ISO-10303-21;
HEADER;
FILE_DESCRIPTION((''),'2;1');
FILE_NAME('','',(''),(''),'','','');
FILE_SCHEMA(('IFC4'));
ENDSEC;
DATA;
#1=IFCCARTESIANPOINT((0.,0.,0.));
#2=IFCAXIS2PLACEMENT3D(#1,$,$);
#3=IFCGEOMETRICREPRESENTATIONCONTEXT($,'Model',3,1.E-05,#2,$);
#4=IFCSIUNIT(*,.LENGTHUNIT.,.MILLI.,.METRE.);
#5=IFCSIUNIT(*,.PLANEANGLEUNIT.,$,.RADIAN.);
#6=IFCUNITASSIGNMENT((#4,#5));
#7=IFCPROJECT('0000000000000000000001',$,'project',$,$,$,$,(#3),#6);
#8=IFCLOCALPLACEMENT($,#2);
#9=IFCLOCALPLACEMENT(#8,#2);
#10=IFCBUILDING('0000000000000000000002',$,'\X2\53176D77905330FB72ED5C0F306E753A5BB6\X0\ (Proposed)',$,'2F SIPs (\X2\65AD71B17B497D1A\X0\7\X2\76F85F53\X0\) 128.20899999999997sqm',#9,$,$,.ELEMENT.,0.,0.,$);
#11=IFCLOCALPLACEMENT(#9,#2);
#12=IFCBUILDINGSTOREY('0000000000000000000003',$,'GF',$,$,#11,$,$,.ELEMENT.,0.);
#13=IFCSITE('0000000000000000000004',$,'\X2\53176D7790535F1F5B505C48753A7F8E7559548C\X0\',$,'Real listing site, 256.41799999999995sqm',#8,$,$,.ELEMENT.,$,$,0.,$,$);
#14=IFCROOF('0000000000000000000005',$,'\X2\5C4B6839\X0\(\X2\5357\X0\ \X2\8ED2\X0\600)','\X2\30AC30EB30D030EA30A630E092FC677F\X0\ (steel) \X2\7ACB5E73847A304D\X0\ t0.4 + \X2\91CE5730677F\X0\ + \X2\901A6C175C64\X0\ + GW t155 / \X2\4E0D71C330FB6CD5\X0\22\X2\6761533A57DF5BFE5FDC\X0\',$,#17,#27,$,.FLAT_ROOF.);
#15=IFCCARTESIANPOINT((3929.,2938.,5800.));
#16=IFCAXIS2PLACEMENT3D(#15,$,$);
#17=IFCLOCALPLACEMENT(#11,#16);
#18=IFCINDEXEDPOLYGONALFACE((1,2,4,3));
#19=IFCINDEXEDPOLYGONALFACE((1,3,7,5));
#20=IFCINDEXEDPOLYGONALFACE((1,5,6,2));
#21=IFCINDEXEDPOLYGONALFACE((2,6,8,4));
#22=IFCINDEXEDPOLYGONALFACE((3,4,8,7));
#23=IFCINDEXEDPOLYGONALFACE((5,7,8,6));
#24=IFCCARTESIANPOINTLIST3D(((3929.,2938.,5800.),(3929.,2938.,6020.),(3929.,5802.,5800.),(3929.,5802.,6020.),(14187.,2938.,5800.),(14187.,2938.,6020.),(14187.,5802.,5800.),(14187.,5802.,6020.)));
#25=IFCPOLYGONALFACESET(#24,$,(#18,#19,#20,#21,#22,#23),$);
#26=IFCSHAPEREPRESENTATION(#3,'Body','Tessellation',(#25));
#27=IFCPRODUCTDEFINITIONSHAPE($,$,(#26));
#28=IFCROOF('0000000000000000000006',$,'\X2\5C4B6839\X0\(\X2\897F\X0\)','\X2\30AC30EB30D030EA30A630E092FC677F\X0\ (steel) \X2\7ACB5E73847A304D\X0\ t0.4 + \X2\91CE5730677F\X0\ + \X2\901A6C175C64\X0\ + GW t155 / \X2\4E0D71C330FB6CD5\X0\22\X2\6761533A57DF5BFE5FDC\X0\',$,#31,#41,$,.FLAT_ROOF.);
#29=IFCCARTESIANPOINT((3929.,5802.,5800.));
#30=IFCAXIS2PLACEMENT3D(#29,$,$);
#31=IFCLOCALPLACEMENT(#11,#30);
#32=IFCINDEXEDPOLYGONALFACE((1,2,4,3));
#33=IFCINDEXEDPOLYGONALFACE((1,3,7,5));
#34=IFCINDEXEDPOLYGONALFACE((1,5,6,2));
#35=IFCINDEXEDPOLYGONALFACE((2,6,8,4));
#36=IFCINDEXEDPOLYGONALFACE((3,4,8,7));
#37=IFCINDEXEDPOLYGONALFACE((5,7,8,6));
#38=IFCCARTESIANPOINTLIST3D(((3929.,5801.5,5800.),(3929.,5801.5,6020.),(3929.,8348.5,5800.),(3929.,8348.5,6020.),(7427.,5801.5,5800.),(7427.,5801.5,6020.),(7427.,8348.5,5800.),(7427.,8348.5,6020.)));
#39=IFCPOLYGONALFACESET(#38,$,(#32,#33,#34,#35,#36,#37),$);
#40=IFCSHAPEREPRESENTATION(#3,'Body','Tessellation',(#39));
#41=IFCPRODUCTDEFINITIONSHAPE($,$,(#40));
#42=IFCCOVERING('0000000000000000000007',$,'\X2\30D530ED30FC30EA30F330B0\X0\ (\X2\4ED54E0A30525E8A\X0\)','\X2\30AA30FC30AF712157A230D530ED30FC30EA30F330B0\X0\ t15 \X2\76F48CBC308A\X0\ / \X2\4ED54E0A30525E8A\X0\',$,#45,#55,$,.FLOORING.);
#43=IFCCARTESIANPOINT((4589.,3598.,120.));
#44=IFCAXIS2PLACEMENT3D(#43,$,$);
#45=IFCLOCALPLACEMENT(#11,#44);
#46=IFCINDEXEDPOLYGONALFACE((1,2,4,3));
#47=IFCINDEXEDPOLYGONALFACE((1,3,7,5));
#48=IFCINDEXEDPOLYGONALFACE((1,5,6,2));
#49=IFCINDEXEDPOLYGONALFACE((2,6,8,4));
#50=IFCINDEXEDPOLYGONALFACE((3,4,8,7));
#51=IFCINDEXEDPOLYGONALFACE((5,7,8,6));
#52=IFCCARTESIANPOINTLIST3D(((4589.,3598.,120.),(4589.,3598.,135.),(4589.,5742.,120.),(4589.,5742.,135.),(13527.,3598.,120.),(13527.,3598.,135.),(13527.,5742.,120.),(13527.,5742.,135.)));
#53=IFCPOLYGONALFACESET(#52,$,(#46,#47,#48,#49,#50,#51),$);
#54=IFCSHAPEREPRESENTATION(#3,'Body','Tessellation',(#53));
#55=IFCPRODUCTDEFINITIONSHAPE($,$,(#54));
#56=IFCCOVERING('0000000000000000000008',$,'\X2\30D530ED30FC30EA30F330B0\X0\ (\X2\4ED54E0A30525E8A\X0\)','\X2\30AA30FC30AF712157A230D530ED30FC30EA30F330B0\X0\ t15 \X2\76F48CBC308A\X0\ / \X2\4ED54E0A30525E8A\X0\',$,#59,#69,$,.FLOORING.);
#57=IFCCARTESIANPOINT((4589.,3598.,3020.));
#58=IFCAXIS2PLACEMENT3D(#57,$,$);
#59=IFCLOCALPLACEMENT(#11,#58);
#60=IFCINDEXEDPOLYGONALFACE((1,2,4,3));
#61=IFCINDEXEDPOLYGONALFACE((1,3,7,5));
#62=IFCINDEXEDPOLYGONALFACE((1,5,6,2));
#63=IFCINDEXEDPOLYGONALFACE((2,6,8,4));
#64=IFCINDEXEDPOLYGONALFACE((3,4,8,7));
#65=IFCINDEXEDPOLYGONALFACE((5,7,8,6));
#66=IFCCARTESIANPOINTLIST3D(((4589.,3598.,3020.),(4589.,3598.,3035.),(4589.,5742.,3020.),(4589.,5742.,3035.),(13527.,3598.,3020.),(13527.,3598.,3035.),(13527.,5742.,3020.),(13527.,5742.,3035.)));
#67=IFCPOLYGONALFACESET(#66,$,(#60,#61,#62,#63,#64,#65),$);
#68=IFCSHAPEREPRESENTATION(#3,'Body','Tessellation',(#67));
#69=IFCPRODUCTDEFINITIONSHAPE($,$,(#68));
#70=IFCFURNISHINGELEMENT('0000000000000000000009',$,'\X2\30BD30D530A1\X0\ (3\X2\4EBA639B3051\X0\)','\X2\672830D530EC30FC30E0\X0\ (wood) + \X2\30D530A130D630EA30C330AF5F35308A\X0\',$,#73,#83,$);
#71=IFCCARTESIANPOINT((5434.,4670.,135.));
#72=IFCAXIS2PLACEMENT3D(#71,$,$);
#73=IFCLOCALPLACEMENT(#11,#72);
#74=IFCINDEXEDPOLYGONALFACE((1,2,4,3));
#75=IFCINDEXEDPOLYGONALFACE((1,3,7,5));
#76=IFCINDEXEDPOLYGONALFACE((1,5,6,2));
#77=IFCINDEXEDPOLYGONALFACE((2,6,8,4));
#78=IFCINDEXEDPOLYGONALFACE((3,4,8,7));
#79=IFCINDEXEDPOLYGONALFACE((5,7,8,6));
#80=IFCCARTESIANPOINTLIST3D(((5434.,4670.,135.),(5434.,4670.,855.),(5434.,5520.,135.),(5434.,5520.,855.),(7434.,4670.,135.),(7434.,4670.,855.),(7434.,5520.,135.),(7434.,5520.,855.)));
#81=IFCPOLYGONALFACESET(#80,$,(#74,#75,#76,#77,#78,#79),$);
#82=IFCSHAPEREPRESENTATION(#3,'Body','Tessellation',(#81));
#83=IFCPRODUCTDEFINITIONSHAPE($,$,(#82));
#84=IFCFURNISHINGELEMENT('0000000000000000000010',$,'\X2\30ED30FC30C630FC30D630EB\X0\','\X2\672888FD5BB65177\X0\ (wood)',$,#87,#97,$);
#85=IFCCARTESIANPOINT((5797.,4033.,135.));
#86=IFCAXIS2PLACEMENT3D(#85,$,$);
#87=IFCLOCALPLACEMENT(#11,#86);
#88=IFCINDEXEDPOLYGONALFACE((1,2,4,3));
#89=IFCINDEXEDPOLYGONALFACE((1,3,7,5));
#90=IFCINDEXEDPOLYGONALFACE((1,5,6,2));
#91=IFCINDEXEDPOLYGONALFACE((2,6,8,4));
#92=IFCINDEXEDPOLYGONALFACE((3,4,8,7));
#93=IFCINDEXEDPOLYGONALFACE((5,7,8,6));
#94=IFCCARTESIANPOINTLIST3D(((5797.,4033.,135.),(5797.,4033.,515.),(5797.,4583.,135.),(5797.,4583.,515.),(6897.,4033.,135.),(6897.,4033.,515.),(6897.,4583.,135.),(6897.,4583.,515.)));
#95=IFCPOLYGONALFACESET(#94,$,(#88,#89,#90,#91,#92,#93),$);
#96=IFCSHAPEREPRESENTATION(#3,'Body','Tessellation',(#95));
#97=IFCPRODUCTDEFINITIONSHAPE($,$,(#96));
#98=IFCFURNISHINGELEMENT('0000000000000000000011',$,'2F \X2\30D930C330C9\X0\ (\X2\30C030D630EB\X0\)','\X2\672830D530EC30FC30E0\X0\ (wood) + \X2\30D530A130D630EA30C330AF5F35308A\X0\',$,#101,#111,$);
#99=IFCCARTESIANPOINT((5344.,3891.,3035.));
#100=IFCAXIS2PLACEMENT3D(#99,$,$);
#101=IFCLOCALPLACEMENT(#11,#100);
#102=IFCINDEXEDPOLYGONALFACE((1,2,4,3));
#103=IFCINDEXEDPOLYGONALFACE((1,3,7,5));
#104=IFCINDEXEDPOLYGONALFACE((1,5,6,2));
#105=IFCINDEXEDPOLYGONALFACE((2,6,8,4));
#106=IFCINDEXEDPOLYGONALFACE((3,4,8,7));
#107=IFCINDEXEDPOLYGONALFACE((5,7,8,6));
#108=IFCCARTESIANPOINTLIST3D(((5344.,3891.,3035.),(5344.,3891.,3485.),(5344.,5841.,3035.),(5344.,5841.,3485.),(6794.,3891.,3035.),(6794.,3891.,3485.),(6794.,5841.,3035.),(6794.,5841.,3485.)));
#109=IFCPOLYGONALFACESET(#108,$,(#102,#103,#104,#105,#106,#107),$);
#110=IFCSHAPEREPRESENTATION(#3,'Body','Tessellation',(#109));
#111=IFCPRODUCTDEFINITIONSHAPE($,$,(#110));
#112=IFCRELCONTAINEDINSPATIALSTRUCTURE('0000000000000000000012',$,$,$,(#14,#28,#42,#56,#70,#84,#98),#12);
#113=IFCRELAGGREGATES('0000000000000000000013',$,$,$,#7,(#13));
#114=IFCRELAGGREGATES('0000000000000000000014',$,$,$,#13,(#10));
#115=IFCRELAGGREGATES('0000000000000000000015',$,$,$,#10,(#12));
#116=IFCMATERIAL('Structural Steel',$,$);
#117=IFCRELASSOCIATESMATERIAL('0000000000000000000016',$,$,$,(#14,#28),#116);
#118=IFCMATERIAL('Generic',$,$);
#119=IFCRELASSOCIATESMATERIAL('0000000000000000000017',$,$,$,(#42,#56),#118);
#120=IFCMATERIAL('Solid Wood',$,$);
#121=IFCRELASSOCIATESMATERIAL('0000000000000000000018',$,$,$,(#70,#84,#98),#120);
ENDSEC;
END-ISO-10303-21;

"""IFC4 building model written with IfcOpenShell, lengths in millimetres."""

from ifc_helpers import new_model, si_unit, frame, frame_2d, origin, place, context, project, spatial, rectangle, extrude, material, element, save


model = new_model("IFC4")

# Units and contexts
model_context = context("Model", 3, precision=1e-05, world=origin())
ifc_project = project(units=[si_unit("LENGTHUNIT", "METRE", prefix="MILLI"), si_unit("PLANEANGLEUNIT", "RADIAN")], contexts=[model_context])

# Site, building, storey
site_placement = place(None, origin())
site = spatial("IfcSite", under=ifc_project, at=site_placement, Name="北海道弟子屈町美留和", ObjectType="Real listing site, 256.41799999999995sqm", CompositionType="ELEMENT", RefElevation=0.0)
building_placement = place(site_placement, origin())
building = spatial("IfcBuilding", under=site, at=building_placement, Name="北海道・狭小の町家 (Proposed)", ObjectType="2F SIPs (断熱等級7相当) 128.20899999999997sqm", CompositionType="ELEMENT", ElevationOfRefHeight=0.0, ElevationOfTerrain=0.0)
storey_placement = place(building_placement, origin())
storey = spatial("IfcBuildingStorey", under=building, at=storey_placement, Name="GF", CompositionType="ELEMENT", Elevation=0.0)

# Shared definitions
ifc_material_1 = material(Name="Solid Wood")

# Roofs
ifc_material_2 = material(Name="Structural Steel")
roof_1_placement = place(storey_placement, frame((3929.0, 2938.0, 5800.0)))
element("IfcRoof", 1, at=roof_1_placement, inside=storey, material=ifc_material_2, Name="屋根(南 軒600)", Description="ガルバリウム鋼板 (steel) 立平葺き t0.4 + 野地板 + 通気層 + GW t155 / 不燃・法22条区域対応", PredefinedType="FLAT_ROOF", context=model_context, shape_type="SweptSolid", body=[
    extrude(rectangle(XDim=10258.0, YDim=2864.0, at=frame_2d((5129.0, 1432.0))), frame((3929.0, 2938.0, 5800.0)), (0.0, 0.0, 1.0), 220.0),
])
roof_2_placement = place(storey_placement, frame((3929.0, 5802.0, 5800.0)))
element("IfcRoof", 2, at=roof_2_placement, inside=storey, material=ifc_material_2, Name="屋根(西)", Description="ガルバリウム鋼板 (steel) 立平葺き t0.4 + 野地板 + 通気層 + GW t155 / 不燃・法22条区域対応", PredefinedType="FLAT_ROOF", context=model_context, shape_type="SweptSolid", body=[
    extrude(rectangle(XDim=3498.0, YDim=2547.0, at=frame_2d((1749.0, 1273.0))), frame((3929.0, 5802.0, 5800.0)), (0.0, 0.0, 1.0), 220.0),
])

# Coverings
ifc_material_3 = material(Name="Generic")
covering_1_placement = place(storey_placement, frame((4589.0, 3598.0, 120.0)))
element("IfcCovering", 3, at=covering_1_placement, inside=storey, material=ifc_material_3, Name="フローリング (仕上げ床)", Description="オーク無垢フローリング t15 直貼り / 仕上げ床", PredefinedType="FLOORING", context=model_context, shape_type="SweptSolid", body=[
    extrude(rectangle(XDim=8938.0, YDim=2144.0, at=frame_2d((4469.0, 1072.0))), frame((4589.0, 3598.0, 120.0)), (0.0, 0.0, 1.0), 15.0),
])
covering_2_placement = place(storey_placement, frame((4589.0, 3598.0, 3020.0)))
element("IfcCovering", 4, at=covering_2_placement, inside=storey, material=ifc_material_3, Name="フローリング (仕上げ床)", Description="オーク無垢フローリング t15 直貼り / 仕上げ床", PredefinedType="FLOORING", context=model_context, shape_type="SweptSolid", body=[
    extrude(rectangle(XDim=8938.0, YDim=2144.0, at=frame_2d((4469.0, 1072.0))), frame((4589.0, 3598.0, 3020.0)), (0.0, 0.0, 1.0), 15.0),
])

# Furnishing elements
furnishing_1_placement = place(storey_placement, frame((5434.0, 4670.0, 135.0)))
element("IfcFurnishingElement", 5, at=furnishing_1_placement, inside=storey, material=ifc_material_1, Name="ソファ (3人掛け)", Description="木フレーム (wood) + ファブリック張り", context=model_context, shape_type="SweptSolid", body=[
    extrude(rectangle(XDim=2000.0, YDim=850.0, at=frame_2d((1000.0, 425.0))), frame((5434.0, 4670.0, 135.0)), (0.0, 0.0, 1.0), 720.0),
])
furnishing_2_placement = place(storey_placement, frame((5797.0, 4033.0, 135.0)))
element("IfcFurnishingElement", 6, at=furnishing_2_placement, inside=storey, material=ifc_material_1, Name="ローテーブル", Description="木製家具 (wood)", context=model_context, shape_type="SweptSolid", body=[
    extrude(rectangle(XDim=1100.0, YDim=550.0, at=frame_2d((550.0, 275.0))), frame((5797.0, 4033.0, 135.0)), (0.0, 0.0, 1.0), 380.0),
])
furnishing_3_placement = place(storey_placement, frame((5344.0, 3891.0, 3035.0)))
element("IfcFurnishingElement", 7, at=furnishing_3_placement, inside=storey, material=ifc_material_1, Name="2F ベッド (ダブル)", Description="木フレーム (wood) + ファブリック張り", context=model_context, shape_type="SweptSolid", body=[
    extrude(rectangle(XDim=1450.0, YDim=1950.0, at=frame_2d((725.0, 975.0))), frame((5344.0, 3891.0, 3035.0)), (0.0, 0.0, 1.0), 450.0),
])

save(model, "model.ifc")
